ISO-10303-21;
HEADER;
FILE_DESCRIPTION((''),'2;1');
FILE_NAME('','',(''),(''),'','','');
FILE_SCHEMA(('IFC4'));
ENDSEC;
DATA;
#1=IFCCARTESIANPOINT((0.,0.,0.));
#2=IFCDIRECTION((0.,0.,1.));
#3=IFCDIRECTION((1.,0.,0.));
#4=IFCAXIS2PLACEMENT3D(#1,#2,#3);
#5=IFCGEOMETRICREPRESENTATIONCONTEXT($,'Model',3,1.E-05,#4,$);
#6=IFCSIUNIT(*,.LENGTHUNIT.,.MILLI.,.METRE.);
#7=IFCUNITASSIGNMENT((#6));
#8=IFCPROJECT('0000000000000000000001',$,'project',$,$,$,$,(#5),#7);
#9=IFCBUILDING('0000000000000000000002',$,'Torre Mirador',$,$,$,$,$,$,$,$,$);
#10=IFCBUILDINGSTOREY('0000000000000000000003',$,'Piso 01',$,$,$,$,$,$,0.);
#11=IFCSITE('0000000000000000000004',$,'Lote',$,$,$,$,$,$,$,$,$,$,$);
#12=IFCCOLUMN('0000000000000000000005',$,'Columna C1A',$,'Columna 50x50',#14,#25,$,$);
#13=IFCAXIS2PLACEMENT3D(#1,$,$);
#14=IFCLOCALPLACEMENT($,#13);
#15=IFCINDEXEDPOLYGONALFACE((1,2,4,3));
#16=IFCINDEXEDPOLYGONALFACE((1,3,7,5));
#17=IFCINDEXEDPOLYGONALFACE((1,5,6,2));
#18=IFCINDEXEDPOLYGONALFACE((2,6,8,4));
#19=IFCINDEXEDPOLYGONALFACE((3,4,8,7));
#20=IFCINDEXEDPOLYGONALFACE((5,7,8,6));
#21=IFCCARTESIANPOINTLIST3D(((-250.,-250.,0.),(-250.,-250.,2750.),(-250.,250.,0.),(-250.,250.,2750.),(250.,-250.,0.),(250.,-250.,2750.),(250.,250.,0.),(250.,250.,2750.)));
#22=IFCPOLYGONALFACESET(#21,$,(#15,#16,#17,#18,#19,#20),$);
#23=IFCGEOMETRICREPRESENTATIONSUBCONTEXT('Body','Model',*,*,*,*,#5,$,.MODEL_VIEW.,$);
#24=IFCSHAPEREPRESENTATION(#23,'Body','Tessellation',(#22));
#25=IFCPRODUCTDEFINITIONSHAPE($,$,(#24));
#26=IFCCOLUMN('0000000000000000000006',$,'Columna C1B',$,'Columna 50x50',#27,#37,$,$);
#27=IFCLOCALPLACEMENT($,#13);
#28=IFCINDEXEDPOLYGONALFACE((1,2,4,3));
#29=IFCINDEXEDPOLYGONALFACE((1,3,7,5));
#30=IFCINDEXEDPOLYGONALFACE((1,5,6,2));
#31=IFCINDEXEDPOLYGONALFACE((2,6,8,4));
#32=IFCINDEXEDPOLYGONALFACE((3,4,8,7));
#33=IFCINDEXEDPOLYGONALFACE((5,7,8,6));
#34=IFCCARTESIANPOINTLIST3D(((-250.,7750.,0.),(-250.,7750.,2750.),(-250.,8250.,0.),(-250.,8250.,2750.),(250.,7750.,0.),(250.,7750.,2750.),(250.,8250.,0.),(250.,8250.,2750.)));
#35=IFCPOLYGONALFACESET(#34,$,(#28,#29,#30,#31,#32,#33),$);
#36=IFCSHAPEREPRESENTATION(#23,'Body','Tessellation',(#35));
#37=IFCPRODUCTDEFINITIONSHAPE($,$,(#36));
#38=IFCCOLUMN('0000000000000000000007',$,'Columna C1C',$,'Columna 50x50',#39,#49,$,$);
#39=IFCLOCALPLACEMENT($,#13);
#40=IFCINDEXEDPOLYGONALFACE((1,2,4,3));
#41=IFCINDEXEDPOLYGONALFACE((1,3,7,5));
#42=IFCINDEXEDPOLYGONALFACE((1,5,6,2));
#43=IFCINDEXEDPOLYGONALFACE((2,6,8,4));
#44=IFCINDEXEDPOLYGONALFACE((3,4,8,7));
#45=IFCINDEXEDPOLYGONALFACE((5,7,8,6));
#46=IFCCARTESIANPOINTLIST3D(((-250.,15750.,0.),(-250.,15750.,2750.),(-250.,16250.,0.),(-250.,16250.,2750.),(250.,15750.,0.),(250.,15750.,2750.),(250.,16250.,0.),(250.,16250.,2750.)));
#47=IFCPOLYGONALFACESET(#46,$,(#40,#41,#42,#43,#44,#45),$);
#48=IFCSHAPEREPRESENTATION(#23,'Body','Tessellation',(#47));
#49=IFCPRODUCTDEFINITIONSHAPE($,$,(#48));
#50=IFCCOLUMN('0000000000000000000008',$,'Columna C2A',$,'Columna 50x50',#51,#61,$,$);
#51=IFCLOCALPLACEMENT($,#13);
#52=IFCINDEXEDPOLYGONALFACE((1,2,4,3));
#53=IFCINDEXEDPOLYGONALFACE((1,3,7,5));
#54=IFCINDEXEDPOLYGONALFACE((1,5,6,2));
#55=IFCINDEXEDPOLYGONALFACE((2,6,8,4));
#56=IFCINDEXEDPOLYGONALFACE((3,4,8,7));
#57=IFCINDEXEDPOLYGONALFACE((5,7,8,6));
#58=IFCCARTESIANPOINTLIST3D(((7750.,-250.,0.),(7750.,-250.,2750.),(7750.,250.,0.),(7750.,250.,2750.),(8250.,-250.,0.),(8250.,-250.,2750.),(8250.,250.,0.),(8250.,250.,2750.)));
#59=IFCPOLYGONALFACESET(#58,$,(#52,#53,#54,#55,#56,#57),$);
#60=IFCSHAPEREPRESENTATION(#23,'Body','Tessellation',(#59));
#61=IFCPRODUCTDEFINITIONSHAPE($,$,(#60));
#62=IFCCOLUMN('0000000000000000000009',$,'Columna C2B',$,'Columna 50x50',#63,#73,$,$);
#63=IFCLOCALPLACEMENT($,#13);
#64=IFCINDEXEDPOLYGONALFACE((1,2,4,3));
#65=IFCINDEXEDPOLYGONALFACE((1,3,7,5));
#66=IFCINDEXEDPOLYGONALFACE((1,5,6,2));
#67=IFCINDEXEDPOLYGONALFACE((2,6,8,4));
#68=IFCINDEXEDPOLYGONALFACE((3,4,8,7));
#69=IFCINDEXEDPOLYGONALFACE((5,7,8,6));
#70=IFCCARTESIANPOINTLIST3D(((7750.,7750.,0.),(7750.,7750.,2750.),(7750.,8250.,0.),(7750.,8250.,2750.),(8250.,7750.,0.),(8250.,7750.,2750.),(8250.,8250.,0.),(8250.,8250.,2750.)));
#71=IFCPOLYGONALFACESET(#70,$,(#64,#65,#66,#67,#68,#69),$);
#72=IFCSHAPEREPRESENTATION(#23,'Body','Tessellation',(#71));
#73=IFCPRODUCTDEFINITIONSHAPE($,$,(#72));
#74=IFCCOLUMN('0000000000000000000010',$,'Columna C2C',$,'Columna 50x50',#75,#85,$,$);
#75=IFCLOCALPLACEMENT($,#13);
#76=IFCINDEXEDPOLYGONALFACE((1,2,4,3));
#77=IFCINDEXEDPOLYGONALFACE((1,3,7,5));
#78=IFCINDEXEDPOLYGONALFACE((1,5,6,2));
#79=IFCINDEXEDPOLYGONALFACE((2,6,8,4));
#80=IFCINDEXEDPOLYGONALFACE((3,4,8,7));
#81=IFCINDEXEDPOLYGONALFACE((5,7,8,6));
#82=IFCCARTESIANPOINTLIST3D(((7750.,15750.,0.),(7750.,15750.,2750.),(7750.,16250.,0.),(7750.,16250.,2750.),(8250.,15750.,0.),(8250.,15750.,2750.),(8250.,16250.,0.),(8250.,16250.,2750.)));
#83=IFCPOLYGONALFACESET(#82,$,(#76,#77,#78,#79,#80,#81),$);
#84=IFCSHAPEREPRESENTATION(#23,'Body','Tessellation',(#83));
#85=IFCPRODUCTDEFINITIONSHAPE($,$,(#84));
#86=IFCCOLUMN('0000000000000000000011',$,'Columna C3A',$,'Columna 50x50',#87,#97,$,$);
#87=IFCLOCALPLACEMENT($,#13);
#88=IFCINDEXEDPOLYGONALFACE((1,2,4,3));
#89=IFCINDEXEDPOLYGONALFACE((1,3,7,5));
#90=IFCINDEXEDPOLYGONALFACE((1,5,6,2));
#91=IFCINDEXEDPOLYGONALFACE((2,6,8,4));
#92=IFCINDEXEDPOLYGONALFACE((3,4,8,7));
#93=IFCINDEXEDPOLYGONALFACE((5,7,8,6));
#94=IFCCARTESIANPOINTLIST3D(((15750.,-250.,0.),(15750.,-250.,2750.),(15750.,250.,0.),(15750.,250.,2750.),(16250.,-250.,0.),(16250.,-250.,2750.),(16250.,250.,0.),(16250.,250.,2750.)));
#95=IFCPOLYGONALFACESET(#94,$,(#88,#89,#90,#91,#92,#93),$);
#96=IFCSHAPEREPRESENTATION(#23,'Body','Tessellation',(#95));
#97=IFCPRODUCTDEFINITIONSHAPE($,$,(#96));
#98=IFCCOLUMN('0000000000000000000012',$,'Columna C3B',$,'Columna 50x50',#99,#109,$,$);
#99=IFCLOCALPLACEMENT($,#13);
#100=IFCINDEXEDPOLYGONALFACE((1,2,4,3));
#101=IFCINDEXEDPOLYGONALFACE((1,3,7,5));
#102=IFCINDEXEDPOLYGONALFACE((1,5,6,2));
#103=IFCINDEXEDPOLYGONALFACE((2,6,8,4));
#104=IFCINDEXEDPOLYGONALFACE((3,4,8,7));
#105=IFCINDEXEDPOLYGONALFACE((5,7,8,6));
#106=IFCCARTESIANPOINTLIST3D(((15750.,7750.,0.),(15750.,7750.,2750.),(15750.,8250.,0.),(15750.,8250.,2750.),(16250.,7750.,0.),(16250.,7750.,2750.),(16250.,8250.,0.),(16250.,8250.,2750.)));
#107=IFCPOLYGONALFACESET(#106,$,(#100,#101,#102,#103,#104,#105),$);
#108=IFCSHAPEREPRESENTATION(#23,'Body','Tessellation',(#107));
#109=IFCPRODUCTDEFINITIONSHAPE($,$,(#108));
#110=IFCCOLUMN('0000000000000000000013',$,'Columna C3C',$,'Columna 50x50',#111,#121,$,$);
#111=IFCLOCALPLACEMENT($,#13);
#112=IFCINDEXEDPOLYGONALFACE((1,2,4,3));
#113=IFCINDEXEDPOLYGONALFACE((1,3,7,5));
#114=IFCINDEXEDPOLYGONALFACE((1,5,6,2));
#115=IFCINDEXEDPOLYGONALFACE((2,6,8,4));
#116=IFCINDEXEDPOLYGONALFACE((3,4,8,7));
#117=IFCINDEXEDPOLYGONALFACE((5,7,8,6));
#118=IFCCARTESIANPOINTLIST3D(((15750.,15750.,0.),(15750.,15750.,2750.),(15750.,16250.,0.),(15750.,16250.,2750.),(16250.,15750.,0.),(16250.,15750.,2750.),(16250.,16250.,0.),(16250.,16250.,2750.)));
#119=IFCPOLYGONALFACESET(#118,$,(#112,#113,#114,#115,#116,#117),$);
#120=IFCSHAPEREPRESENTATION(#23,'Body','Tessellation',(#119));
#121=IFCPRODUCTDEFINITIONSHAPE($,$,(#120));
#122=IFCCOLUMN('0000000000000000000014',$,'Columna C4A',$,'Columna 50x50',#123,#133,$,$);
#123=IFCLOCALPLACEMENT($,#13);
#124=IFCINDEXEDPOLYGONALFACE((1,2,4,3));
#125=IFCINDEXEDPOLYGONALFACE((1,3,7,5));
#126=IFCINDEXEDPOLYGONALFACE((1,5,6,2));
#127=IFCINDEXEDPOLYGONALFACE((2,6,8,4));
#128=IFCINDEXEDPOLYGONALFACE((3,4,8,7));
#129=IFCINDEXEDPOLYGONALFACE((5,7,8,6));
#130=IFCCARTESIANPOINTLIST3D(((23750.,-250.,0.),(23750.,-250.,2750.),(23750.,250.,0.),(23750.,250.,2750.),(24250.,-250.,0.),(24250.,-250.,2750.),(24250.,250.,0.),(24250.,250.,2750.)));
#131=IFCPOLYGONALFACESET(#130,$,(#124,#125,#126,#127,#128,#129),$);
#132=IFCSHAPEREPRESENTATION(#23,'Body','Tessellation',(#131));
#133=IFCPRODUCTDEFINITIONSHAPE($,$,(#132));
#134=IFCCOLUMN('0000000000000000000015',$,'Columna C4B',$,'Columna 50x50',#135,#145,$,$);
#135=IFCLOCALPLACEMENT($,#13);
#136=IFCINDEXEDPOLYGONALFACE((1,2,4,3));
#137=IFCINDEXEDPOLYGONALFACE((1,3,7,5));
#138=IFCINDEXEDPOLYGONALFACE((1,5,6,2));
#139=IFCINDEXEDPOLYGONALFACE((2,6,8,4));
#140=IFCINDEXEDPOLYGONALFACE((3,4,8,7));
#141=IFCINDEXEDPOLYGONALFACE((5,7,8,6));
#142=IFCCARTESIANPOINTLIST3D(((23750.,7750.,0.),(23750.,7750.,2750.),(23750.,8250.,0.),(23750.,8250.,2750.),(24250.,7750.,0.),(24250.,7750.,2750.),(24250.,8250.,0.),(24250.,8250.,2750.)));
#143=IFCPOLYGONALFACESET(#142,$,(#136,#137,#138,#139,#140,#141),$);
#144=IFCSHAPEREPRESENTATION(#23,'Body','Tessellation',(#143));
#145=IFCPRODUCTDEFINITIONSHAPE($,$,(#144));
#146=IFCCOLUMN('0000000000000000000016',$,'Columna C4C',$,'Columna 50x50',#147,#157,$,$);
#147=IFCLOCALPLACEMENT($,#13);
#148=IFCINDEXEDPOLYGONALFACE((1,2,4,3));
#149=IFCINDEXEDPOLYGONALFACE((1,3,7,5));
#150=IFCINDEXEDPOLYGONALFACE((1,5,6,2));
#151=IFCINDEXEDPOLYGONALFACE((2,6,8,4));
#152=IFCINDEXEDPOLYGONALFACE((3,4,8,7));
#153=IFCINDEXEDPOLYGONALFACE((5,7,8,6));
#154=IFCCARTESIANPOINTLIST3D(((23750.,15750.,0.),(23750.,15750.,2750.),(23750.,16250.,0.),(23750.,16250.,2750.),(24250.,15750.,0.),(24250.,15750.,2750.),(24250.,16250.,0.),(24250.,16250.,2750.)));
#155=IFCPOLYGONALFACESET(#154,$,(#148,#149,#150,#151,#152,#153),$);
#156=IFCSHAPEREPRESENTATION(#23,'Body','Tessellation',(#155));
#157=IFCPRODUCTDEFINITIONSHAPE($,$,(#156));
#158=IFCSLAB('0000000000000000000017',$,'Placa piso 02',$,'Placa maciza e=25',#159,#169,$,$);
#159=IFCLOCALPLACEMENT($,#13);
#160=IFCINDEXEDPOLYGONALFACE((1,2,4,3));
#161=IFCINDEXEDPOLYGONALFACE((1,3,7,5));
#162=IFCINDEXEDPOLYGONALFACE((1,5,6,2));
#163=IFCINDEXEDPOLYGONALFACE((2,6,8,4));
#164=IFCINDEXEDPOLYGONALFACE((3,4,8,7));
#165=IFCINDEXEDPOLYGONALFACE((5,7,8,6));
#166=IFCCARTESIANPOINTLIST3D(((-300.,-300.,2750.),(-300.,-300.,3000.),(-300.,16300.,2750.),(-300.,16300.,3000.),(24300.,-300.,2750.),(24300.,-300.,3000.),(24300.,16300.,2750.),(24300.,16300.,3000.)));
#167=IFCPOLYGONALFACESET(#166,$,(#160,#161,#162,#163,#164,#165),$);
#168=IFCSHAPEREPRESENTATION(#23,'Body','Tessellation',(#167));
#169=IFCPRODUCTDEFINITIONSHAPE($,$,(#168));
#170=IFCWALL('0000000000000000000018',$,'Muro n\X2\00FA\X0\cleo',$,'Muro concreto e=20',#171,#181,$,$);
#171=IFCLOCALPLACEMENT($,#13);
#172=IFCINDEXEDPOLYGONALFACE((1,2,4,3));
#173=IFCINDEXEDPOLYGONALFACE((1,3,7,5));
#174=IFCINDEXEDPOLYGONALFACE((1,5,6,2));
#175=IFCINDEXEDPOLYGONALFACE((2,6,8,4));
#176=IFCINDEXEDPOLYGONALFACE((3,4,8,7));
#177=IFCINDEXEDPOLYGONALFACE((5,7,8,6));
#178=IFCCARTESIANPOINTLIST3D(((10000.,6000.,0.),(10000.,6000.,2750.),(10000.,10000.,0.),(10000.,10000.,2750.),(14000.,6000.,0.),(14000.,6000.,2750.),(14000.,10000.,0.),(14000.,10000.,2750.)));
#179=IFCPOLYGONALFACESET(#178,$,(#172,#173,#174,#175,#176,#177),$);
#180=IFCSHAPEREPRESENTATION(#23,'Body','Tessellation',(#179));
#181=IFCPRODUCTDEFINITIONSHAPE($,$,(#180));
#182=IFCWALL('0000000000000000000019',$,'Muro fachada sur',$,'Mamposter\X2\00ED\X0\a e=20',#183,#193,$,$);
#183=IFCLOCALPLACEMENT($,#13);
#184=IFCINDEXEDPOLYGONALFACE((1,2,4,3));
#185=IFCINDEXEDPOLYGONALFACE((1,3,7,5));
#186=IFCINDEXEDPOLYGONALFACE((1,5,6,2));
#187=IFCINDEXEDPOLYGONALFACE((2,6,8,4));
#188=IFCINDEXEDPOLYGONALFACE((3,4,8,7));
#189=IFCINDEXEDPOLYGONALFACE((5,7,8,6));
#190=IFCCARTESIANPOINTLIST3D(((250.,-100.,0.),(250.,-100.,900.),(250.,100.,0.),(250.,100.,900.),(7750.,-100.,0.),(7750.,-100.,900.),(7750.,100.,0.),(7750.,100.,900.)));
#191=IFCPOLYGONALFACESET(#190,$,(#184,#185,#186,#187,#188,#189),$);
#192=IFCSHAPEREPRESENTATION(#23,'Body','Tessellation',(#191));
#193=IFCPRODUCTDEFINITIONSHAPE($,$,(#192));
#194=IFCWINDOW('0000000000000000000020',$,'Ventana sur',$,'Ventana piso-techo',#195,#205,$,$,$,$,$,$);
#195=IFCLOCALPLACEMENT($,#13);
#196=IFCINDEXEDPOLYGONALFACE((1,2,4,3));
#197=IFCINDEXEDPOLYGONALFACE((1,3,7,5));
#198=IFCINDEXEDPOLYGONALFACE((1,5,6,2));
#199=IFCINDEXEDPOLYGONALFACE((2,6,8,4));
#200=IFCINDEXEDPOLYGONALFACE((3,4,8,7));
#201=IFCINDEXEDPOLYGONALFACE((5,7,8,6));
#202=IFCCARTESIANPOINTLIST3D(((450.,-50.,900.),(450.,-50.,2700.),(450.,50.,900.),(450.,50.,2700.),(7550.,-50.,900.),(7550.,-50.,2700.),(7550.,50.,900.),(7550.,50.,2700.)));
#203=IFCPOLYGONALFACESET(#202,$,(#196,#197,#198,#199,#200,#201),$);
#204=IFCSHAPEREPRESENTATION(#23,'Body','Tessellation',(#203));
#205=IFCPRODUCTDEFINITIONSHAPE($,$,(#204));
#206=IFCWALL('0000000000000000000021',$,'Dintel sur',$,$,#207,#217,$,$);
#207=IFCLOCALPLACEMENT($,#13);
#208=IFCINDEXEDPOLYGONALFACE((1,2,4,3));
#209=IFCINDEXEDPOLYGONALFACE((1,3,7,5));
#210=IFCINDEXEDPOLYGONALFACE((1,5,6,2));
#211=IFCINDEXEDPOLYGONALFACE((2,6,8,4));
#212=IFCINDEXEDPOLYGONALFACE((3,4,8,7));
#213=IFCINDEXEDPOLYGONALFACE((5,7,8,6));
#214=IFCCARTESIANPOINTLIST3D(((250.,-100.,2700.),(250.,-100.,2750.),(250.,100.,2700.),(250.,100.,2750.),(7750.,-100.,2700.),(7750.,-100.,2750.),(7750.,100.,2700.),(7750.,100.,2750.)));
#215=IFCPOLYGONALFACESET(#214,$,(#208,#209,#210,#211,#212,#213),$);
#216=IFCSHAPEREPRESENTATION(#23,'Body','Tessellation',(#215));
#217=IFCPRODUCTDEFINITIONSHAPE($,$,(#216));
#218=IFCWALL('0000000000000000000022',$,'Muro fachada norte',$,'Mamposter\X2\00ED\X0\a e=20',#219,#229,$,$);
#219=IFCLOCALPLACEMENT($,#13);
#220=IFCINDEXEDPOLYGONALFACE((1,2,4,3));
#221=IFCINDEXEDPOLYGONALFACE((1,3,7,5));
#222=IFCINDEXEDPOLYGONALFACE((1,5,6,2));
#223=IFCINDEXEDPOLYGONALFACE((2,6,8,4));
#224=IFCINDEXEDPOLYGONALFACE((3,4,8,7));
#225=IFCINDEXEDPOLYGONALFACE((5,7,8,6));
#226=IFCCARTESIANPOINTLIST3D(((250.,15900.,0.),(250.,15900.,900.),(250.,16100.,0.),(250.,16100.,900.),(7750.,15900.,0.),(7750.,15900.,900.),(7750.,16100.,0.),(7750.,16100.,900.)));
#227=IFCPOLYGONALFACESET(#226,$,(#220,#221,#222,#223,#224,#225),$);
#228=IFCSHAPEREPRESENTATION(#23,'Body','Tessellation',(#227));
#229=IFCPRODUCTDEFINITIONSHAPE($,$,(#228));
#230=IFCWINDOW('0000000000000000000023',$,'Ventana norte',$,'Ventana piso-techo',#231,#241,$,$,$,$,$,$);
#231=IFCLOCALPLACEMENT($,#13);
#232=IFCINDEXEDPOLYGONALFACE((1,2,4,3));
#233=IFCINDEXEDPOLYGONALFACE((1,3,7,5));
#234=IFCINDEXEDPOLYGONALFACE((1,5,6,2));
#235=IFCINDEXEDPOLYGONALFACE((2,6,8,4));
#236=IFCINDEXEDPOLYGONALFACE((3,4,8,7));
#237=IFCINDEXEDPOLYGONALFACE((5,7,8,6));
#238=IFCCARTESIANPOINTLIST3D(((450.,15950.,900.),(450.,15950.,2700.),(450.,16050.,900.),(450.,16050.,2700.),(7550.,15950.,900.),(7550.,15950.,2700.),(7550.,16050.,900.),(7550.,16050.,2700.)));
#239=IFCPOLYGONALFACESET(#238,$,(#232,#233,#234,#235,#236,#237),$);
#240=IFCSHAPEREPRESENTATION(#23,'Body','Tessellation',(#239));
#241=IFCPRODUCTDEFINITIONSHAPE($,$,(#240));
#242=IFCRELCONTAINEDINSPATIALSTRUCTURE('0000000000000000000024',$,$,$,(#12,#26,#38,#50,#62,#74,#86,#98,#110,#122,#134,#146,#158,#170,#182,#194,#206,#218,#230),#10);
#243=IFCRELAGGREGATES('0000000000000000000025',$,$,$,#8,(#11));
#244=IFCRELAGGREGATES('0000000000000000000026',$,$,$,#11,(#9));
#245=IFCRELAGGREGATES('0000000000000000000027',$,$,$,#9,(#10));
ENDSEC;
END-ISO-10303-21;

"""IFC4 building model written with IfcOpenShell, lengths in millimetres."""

from ifc_helpers import new_model, si_unit, frame, origin_with_axes, place, context, subcontext, project, spatial, indexed_curve, outline, extrude, element, save


model = new_model("IFC4")

# Units and contexts
model_context = context("Model", 3, precision=1e-05, world=origin_with_axes())
body_context = subcontext(model_context, "Body", "Model", "MODEL_VIEW")
ifc_project = project(units=[si_unit("LENGTHUNIT", "METRE", prefix="MILLI")], contexts=[model_context])

# Site, building, storey
site = spatial("IfcSite", under=ifc_project, Name="Lote")
building = spatial("IfcBuilding", under=site, Name="Torre Mirador")
storey = spatial("IfcBuildingStorey", under=building, Name="Piso 01", Elevation=0.0)

# Columns
for number, where, z_axis, x_axis, name in (
    (1, (-250.0, -250.0, 0.0), (0.0, 0.0, 1.0), (1.0, 0.0, 0.0), "Columna C1A"),
    (2, (-250.0, 7750.0, 0.0), (0.0, 0.0, 1.0), (1.0, 0.0, 0.0), "Columna C1B"),
    (3, (-250.0, 15750.0, 0.0), (0.0, 0.0, 1.0), (1.0, 0.0, 0.0), "Columna C1C"),
    (4, (7750.0, -250.0, 0.0), (0.0, 0.0, 1.0), (1.0, 0.0, 0.0), "Columna C2A"),
    (5, (7750.0, 7750.0, 0.0), (0.0, 0.0, 1.0), (1.0, 0.0, 0.0), "Columna C2B"),
    (6, (7750.0, 15750.0, 0.0), (0.0, 0.0, 1.0), (1.0, 0.0, 0.0), "Columna C2C"),
    (7, (15750.0, -250.0, 0.0), (0.0, 0.0, 1.0), (1.0, 0.0, 0.0), "Columna C3A"),
    (8, (15750.0, 7750.0, 0.0), (0.0, 0.0, 1.0), (1.0, 0.0, 0.0), "Columna C3B"),
    (9, (15750.0, 15750.0, 0.0), (0.0, 0.0, 1.0), (1.0, 0.0, 0.0), "Columna C3C"),
    (10, (23750.0, -250.0, 0.0), (0.0, 0.0, 1.0), (1.0, 0.0, 0.0), "Columna C4A"),
    (11, (23750.0, 7750.0, 0.0), (0.0, 0.0, 1.0), (1.0, 0.0, 0.0), "Columna C4B"),
    (12, (23750.0, 15750.0, 0.0), (0.0, 0.0, 1.0), (1.0, 0.0, 0.0), "Columna C4C"),
):
    element("IfcColumn", number, at=place(None, frame(where, z_axis=z_axis, x_axis=x_axis)), inside=storey, Name=name, ObjectType="Columna 50x50", context=body_context, shape_type="SweptSolid", body=[
        extrude(outline(indexed_curve([(0.0, 0.0), (0.0, 500.0), (500.0, 500.0), (500.0, 0.0), (0.0, 0.0)], self_intersect=False)), origin_with_axes(), (0.0, 0.0, 1.0), 2750.0),
    ])

# Slab
slab_placement = place(None, frame((-300.0, -300.0, 2750.0), z_axis=(0.0, 0.0, 1.0), x_axis=(1.0, 0.0, 0.0)))
element("IfcSlab", 13, at=slab_placement, inside=storey, Name="Placa piso 02", ObjectType="Placa maciza e=25", context=body_context, shape_type="SweptSolid", body=[
    extrude(outline(indexed_curve([(0.0, 0.0), (0.0, 16600.0), (24600.0, 16600.0), (24600.0, 0.0), (0.0, 0.0)], self_intersect=False)), origin_with_axes(), (0.0, 0.0, 1.0), 250.0),
])

# Walls
wall_1_placement = place(None, frame((10000.0, 6000.0, 0.0), z_axis=(0.0, 0.0, 1.0), x_axis=(1.0, 0.0, 0.0)))
element("IfcWall", 14, at=wall_1_placement, inside=storey, Name="Muro núcleo", ObjectType="Muro concreto e=20", context=body_context, shape_type="SweptSolid", body=[
    extrude(outline(indexed_curve([(0.0, 0.0), (0.0, 4000.0), (4000.0, 4000.0), (4000.0, 0.0), (0.0, 0.0)], self_intersect=False)), origin_with_axes(), (0.0, 0.0, 1.0), 2750.0),
])
wall_2_placement = place(None, frame((250.0, -100.0, 0.0), z_axis=(0.0, 0.0, 1.0), x_axis=(1.0, 0.0, 0.0)))
element("IfcWall", 15, at=wall_2_placement, inside=storey, Name="Muro fachada sur", ObjectType="Mampostería e=20", context=body_context, shape_type="SweptSolid", body=[
    extrude(outline(indexed_curve([(0.0, 0.0), (0.0, 200.0), (7500.0, 200.0), (7500.0, 0.0), (0.0, 0.0)], self_intersect=False)), origin_with_axes(), (0.0, 0.0, 1.0), 900.0),
])

# Window
window_1_placement = place(None, frame((450.0, -50.0, 900.0), z_axis=(0.0, 0.0, 1.0), x_axis=(1.0, 0.0, 0.0)))
element("IfcWindow", 16, at=window_1_placement, inside=storey, Name="Ventana sur", ObjectType="Ventana piso-techo", context=body_context, shape_type="SweptSolid", body=[
    extrude(outline(indexed_curve([(0.0, 0.0), (0.0, 100.0), (7100.0, 100.0), (7100.0, 0.0), (0.0, 0.0)], self_intersect=False)), origin_with_axes(), (0.0, 0.0, 1.0), 1800.0),
])

# Walls
wall_3_placement = place(None, frame((250.0, -100.0, 2700.0), z_axis=(0.0, 0.0, 1.0), x_axis=(1.0, 0.0, 0.0)))
element("IfcWall", 17, at=wall_3_placement, inside=storey, Name="Dintel sur", context=body_context, shape_type="SweptSolid", body=[
    extrude(outline(indexed_curve([(0.0, 0.0), (0.0, 200.0), (7500.0, 200.0), (7500.0, 0.0), (0.0, 0.0)], self_intersect=False)), origin_with_axes(), (0.0, 0.0, 1.0), 50.0),
])
wall_4_placement = place(None, frame((250.0, 15900.0, 0.0), z_axis=(0.0, 0.0, 1.0), x_axis=(1.0, 0.0, 0.0)))
element("IfcWall", 18, at=wall_4_placement, inside=storey, Name="Muro fachada norte", ObjectType="Mampostería e=20", context=body_context, shape_type="SweptSolid", body=[
    extrude(outline(indexed_curve([(0.0, 0.0), (0.0, 200.0), (7500.0, 200.0), (7500.0, 0.0), (0.0, 0.0)], self_intersect=False)), origin_with_axes(), (0.0, 0.0, 1.0), 900.0),
])

# Window
window_2_placement = place(None, frame((450.0, 15950.0, 900.0), z_axis=(0.0, 0.0, 1.0), x_axis=(1.0, 0.0, 0.0)))
element("IfcWindow", 19, at=window_2_placement, inside=storey, Name="Ventana norte", ObjectType="Ventana piso-techo", context=body_context, shape_type="SweptSolid", body=[
    extrude(outline(indexed_curve([(0.0, 0.0), (0.0, 100.0), (7100.0, 100.0), (7100.0, 0.0), (0.0, 0.0)], self_intersect=False)), origin_with_axes(), (0.0, 0.0, 1.0), 1800.0),
])

save(model, "model.ifc")
